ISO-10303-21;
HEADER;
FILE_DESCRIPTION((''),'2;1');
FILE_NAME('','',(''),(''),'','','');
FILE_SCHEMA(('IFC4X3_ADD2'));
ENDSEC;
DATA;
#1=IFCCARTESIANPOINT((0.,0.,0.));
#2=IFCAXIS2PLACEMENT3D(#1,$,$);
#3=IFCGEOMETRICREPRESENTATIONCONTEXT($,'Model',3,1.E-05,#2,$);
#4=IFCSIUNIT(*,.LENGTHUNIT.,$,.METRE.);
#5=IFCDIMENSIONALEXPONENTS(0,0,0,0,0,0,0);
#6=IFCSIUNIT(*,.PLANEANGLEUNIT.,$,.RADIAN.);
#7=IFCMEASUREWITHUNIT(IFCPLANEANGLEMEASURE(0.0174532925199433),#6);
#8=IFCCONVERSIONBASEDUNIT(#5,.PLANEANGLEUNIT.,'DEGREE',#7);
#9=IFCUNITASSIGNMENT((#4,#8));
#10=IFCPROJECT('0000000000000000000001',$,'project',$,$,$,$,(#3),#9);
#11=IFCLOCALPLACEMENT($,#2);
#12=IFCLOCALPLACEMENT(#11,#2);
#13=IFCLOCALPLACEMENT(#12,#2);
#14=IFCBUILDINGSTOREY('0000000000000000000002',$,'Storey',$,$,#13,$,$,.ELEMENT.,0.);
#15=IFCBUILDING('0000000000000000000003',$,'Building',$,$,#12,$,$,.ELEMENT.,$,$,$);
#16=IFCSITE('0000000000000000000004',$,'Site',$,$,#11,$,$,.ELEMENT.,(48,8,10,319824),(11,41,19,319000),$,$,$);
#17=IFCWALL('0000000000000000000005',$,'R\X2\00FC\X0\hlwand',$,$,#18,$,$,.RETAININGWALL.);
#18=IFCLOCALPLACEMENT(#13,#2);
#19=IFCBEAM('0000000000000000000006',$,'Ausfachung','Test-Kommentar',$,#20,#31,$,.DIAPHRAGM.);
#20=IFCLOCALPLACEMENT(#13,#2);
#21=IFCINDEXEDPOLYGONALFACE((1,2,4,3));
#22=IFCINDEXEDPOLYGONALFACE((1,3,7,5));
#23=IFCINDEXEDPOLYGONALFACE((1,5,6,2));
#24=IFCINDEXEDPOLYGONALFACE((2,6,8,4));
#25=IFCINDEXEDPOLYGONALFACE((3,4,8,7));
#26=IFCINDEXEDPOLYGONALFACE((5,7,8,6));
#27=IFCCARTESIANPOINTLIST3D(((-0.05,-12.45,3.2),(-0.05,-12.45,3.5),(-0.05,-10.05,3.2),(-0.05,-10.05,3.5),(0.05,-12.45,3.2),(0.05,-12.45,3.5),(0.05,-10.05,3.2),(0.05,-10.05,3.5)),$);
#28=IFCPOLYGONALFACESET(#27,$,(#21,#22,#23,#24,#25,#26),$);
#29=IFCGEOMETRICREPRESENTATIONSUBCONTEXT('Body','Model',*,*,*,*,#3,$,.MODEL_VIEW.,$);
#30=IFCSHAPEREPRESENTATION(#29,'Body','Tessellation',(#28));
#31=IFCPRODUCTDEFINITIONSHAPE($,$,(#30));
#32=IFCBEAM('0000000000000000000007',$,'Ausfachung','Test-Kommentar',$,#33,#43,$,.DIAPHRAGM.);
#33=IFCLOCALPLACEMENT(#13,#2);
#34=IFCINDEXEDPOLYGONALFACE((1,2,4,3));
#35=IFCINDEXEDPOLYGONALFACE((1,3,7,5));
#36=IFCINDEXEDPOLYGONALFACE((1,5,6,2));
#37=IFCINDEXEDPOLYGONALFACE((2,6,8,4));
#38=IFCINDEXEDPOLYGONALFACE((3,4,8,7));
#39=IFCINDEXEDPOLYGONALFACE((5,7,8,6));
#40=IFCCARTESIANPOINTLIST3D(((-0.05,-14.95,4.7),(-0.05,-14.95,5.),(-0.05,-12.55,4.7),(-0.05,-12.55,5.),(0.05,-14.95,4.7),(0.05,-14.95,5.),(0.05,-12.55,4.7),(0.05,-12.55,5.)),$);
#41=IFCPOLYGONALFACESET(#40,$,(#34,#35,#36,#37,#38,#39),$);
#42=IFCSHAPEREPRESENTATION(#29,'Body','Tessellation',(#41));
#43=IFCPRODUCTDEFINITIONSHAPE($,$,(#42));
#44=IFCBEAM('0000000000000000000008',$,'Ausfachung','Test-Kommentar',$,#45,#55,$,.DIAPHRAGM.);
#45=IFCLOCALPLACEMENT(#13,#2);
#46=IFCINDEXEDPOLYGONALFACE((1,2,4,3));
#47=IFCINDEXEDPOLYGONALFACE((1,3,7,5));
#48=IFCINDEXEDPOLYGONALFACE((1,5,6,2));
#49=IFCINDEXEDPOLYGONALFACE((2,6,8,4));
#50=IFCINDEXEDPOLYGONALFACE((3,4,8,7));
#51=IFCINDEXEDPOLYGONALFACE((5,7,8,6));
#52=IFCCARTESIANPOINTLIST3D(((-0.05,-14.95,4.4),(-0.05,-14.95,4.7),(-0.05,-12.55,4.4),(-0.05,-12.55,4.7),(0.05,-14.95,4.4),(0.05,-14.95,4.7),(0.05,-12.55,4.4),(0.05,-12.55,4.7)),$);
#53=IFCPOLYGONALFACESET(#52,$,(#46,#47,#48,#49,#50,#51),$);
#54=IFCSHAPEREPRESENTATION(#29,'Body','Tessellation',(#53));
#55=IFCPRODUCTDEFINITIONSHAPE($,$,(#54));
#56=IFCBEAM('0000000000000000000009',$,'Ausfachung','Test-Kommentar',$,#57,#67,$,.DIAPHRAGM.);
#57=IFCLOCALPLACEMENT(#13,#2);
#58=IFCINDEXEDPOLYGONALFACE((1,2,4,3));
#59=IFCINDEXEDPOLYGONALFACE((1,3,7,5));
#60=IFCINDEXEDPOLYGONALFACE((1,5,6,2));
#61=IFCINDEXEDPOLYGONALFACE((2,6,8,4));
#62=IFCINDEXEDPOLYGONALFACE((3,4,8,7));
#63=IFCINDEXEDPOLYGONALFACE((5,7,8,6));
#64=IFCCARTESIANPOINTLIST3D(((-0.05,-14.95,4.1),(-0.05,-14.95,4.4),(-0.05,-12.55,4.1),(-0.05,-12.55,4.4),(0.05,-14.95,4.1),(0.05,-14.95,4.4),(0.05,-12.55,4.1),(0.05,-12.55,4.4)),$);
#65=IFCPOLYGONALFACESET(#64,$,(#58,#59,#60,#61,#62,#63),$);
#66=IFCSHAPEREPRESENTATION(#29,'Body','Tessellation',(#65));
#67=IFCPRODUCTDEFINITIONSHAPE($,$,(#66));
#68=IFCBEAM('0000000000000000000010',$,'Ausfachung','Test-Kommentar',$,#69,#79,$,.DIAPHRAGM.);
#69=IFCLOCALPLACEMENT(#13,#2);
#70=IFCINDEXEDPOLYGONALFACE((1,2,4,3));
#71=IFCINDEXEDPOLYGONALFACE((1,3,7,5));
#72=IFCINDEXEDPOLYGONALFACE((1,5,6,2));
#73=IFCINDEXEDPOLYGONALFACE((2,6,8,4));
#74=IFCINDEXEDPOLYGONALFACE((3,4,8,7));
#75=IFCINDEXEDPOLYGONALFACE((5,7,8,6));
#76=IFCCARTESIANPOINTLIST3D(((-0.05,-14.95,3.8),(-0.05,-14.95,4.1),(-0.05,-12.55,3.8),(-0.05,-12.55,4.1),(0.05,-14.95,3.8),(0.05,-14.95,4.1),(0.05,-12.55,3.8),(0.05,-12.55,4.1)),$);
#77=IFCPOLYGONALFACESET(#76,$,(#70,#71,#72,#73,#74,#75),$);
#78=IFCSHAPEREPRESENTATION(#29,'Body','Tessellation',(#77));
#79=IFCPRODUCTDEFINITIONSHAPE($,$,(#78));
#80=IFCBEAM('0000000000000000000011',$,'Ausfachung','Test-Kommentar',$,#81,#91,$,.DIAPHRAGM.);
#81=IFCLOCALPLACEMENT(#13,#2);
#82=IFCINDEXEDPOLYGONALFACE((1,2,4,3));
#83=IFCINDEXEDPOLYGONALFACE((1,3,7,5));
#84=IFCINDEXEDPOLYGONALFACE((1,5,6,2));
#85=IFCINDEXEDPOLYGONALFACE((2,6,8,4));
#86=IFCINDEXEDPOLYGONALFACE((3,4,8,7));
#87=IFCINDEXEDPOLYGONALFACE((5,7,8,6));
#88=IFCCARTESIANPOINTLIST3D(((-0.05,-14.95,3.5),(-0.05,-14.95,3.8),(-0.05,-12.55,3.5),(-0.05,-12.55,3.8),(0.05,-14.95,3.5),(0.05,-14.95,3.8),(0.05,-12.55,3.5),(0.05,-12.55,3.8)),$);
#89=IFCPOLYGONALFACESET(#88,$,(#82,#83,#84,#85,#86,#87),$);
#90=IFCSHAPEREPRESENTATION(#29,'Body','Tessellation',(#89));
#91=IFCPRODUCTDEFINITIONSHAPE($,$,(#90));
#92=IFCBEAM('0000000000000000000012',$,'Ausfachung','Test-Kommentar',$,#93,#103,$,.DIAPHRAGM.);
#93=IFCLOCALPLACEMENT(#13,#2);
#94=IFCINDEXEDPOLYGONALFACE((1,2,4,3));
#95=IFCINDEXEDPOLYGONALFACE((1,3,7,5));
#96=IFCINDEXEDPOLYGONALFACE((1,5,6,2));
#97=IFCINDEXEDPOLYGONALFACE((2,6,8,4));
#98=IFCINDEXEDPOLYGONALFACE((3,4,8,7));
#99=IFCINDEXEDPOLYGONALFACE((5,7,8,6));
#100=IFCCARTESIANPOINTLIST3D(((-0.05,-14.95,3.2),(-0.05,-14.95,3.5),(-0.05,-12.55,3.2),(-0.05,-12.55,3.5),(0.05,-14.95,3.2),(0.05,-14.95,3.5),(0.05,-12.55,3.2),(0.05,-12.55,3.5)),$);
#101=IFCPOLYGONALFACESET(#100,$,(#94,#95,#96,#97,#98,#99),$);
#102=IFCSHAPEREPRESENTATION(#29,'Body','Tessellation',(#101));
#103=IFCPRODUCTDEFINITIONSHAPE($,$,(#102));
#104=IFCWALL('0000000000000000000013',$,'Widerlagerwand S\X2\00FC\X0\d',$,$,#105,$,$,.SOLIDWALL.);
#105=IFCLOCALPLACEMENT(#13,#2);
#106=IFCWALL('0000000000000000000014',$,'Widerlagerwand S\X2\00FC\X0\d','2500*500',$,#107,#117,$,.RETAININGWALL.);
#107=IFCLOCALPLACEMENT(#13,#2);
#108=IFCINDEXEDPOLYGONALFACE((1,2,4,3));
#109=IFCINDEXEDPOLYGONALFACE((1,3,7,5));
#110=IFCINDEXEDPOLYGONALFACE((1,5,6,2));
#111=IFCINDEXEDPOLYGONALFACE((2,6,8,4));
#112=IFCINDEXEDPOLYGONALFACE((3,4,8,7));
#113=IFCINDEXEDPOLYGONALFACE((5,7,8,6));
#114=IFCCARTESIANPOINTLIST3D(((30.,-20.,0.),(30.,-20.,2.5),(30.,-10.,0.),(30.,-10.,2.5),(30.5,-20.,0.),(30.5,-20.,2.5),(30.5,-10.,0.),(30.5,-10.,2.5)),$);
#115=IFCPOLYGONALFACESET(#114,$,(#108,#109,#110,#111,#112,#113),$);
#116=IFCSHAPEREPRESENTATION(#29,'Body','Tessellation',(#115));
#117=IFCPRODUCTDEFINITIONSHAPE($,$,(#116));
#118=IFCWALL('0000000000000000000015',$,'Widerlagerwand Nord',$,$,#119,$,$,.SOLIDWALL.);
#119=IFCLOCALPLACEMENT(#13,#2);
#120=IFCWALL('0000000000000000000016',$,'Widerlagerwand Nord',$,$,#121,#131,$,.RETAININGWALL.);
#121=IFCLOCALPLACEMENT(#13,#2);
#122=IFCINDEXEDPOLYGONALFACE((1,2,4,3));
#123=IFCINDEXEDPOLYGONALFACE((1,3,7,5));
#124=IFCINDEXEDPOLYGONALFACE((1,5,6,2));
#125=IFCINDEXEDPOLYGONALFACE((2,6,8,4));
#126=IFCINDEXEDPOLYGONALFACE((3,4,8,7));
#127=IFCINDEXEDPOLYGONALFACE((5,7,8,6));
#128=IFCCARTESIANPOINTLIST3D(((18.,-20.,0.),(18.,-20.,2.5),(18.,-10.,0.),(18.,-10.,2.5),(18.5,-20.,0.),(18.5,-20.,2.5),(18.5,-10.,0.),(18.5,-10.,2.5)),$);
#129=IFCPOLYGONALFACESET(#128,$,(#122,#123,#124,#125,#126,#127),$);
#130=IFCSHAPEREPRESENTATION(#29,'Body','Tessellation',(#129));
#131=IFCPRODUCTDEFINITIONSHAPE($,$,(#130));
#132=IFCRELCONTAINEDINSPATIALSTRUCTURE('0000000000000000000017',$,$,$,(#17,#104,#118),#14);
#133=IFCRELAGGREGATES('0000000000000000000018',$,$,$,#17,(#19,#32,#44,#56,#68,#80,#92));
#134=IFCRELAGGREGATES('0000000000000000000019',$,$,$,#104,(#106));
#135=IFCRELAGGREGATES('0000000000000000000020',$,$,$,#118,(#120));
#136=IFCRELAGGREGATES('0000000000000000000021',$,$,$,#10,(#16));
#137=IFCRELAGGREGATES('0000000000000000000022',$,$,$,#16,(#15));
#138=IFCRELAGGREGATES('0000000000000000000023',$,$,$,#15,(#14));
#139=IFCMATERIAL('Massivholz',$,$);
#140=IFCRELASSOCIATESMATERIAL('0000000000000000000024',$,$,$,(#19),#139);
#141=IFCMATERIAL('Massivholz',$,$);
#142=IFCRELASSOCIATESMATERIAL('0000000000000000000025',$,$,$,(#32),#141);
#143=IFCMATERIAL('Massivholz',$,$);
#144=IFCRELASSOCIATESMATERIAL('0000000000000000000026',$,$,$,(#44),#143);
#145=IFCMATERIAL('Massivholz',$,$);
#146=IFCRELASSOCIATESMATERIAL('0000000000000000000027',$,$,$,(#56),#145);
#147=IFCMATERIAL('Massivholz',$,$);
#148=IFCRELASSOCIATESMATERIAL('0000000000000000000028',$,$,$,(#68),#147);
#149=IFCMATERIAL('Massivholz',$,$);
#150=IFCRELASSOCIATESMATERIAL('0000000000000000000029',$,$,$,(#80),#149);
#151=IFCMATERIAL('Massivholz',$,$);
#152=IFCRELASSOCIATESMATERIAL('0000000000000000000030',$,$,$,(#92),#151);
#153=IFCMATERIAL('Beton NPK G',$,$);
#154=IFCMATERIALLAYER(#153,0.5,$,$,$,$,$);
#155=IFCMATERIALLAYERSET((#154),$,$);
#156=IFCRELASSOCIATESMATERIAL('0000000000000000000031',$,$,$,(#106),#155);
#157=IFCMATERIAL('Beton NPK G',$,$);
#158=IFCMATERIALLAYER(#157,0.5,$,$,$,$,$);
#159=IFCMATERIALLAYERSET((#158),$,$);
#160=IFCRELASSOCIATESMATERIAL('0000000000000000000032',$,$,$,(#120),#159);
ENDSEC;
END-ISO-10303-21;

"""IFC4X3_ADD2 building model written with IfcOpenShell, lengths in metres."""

from ifc_helpers import new_model, entity, si_unit, converted_unit, frame, frame_2d, origin, origin_with_axes, place, context, subcontext, project, spatial, rectangle, extrude, material, layer, layer_set, layer_usage, element, aggregate, save


model = new_model("IFC4X3_ADD2")

# Units and contexts
model_context = context("Model", 3, precision=1e-05, world=origin())
body_context = subcontext(model_context, "Body", "Model", "MODEL_VIEW")
ifc_project = project(units=[si_unit("LENGTHUNIT", "METRE"), converted_unit("PLANEANGLEUNIT", "DEGREE", entity("IfcPlaneAngleMeasure", 0.0174532925199433), si_unit("PLANEANGLEUNIT", "RADIAN"), dimensions=[0, 0, 0, 0, 0, 0, 0])], contexts=[model_context])

# Site, building, storey
site_placement = place(None, origin())
site = spatial("IfcSite", under=ifc_project, at=site_placement, Name="Site", CompositionType="ELEMENT", RefLatitude=(48, 8, 10, 319824), RefLongitude=(11, 41, 19, 319000))
building_placement = place(site_placement, origin())
building = spatial("IfcBuilding", under=site, at=building_placement, Name="Building", CompositionType="ELEMENT")
storey_placement = place(building_placement, origin())
storey = spatial("IfcBuildingStorey", under=building, at=storey_placement, Name="Storey", CompositionType="ELEMENT", Elevation=0.0)

# Wall, beams
wall_1_placement = place(storey_placement, origin())
wall_1 = element("IfcWall", 1, at=wall_1_placement, inside=storey, Name="Rühlwand", PredefinedType="RETAININGWALL")
ifc_material_1 = material(Name="Massivholz")
beam_1_placement = place(wall_1_placement, frame((0.05, -10.05, 3.2), z_axis=(0.0, 0.0, 1.0), x_axis=(-1.0, 0.0, 0.0)))
beam_1 = element("IfcBeam", 2, at=beam_1_placement, material=ifc_material_1, Name="Ausfachung", Description="Test-Kommentar", PredefinedType="DIAPHRAGM", context=body_context, shape_type="SweptSolid", body=[
    extrude(rectangle(XDim=2.4, YDim=0.3, at=frame_2d((1.2, 0.15), x_axis=(1.0, 0.0))), frame((0.0, 0.0, 0.0), z_axis=(1.0, 0.0, 0.0), x_axis=(0.0, 1.0, 0.0)), (0.0, 0.0, 1.0), 0.1),
])
ifc_material_2 = material(Name="Massivholz")
beam_2_placement = place(wall_1_placement, frame((0.05, -12.55, 4.7), z_axis=(0.0, 0.0, 1.0), x_axis=(-1.0, 0.0, 0.0)))
beam_2 = element("IfcBeam", 3, at=beam_2_placement, material=ifc_material_2, Name="Ausfachung", Description="Test-Kommentar", PredefinedType="DIAPHRAGM", context=body_context, shape_type="SweptSolid", body=[
    extrude(rectangle(XDim=2.4, YDim=0.3, at=frame_2d((1.2, 0.15), x_axis=(1.0, 0.0))), frame((0.0, 0.0, 0.0), z_axis=(1.0, 0.0, 0.0), x_axis=(0.0, 1.0, 0.0)), (0.0, 0.0, 1.0), 0.1),
])
ifc_material_3 = material(Name="Massivholz")
beam_3_placement = place(wall_1_placement, frame((0.05, -12.55, 4.4), z_axis=(0.0, 0.0, 1.0), x_axis=(-1.0, 0.0, 0.0)))
beam_3 = element("IfcBeam", 4, at=beam_3_placement, material=ifc_material_3, Name="Ausfachung", Description="Test-Kommentar", PredefinedType="DIAPHRAGM", context=body_context, shape_type="SweptSolid", body=[
    extrude(rectangle(XDim=2.4, YDim=0.3, at=frame_2d((1.2, 0.15), x_axis=(1.0, 0.0))), frame((0.0, 0.0, 0.0), z_axis=(1.0, 0.0, 0.0), x_axis=(0.0, 1.0, 0.0)), (0.0, 0.0, 1.0), 0.1),
])
ifc_material_4 = material(Name="Massivholz")
beam_4_placement = place(wall_1_placement, frame((0.05, -12.55, 4.1), z_axis=(0.0, 0.0, 1.0), x_axis=(-1.0, 0.0, 0.0)))
beam_4 = element("IfcBeam", 5, at=beam_4_placement, material=ifc_material_4, Name="Ausfachung", Description="Test-Kommentar", PredefinedType="DIAPHRAGM", context=body_context, shape_type="SweptSolid", body=[
    extrude(rectangle(XDim=2.4, YDim=0.3, at=frame_2d((1.2, 0.15), x_axis=(1.0, 0.0))), frame((0.0, 0.0, 0.0), z_axis=(1.0, 0.0, 0.0), x_axis=(0.0, 1.0, 0.0)), (0.0, 0.0, 1.0), 0.1),
])
ifc_material_5 = material(Name="Massivholz")
beam_5_placement = place(wall_1_placement, frame((0.05, -12.55, 3.8), z_axis=(0.0, 0.0, 1.0), x_axis=(-1.0, 0.0, 0.0)))
beam_5 = element("IfcBeam", 6, at=beam_5_placement, material=ifc_material_5, Name="Ausfachung", Description="Test-Kommentar", PredefinedType="DIAPHRAGM", context=body_context, shape_type="SweptSolid", body=[
    extrude(rectangle(XDim=2.4, YDim=0.3, at=frame_2d((1.2, 0.15), x_axis=(1.0, 0.0))), frame((0.0, 0.0, 0.0), z_axis=(1.0, 0.0, 0.0), x_axis=(0.0, 1.0, 0.0)), (0.0, 0.0, 1.0), 0.1),
])
ifc_material_6 = material(Name="Massivholz")
beam_6_placement = place(wall_1_placement, frame((0.05, -12.55, 3.5), z_axis=(0.0, 0.0, 1.0), x_axis=(-1.0, 0.0, 0.0)))
beam_6 = element("IfcBeam", 7, at=beam_6_placement, material=ifc_material_6, Name="Ausfachung", Description="Test-Kommentar", PredefinedType="DIAPHRAGM", context=body_context, shape_type="SweptSolid", body=[
    extrude(rectangle(XDim=2.4, YDim=0.3, at=frame_2d((1.2, 0.15), x_axis=(1.0, 0.0))), frame((0.0, 0.0, 0.0), z_axis=(1.0, 0.0, 0.0), x_axis=(0.0, 1.0, 0.0)), (0.0, 0.0, 1.0), 0.1),
])
ifc_material_7 = material(Name="Massivholz")
beam_7_placement = place(wall_1_placement, frame((0.05, -12.55, 3.2), z_axis=(0.0, 0.0, 1.0), x_axis=(-1.0, 0.0, 0.0)))
beam_7 = element("IfcBeam", 8, at=beam_7_placement, material=ifc_material_7, Name="Ausfachung", Description="Test-Kommentar", PredefinedType="DIAPHRAGM", context=body_context, shape_type="SweptSolid", body=[
    extrude(rectangle(XDim=2.4, YDim=0.3, at=frame_2d((1.2, 0.15), x_axis=(1.0, 0.0))), frame((0.0, 0.0, 0.0), z_axis=(1.0, 0.0, 0.0), x_axis=(0.0, 1.0, 0.0)), (0.0, 0.0, 1.0), 0.1),
])
aggregate(wall_1, [beam_1, beam_2, beam_3, beam_4, beam_5, beam_6, beam_7])

# Walls
wall_2_placement = place(storey_placement, origin())
wall_2 = element("IfcWall", 9, at=wall_2_placement, inside=storey, Name="Widerlagerwand Süd", PredefinedType="SOLIDWALL")
ifc_material_8 = material(Name="Beton NPK G")
ifc_layer_1 = layer(ifc_material_8, 0.5)
ifc_layer_set_1 = layer_set([ifc_layer_1])
ifc_layer_usage_1 = layer_usage(ifc_layer_set_1, "AXIS2", "POSITIVE", 0.0)
wall_3_placement = place(wall_2_placement, frame((30.5, -20.0, 0.0), z_axis=(0.0, 0.0, 1.0), x_axis=(0.0, 1.0, 0.0)))
wall_3 = element("IfcWall", 10, at=wall_3_placement, material=ifc_layer_usage_1, Name="Widerlagerwand Süd", Description="2500*500", PredefinedType="RETAININGWALL", context=body_context, shape_type="SweptSolid", body=[
    extrude(rectangle(XDim=10.0, YDim=0.5, at=frame_2d((5.0, 0.25), x_axis=(1.0, 0.0))), origin_with_axes(), (0.0, 0.0, 1.0), 2.5),
])
aggregate(wall_2, [wall_3])
wall_4_placement = place(storey_placement, origin())
wall_4 = element("IfcWall", 11, at=wall_4_placement, inside=storey, Name="Widerlagerwand Nord", PredefinedType="SOLIDWALL")
ifc_material_9 = material(Name="Beton NPK G")
ifc_layer_2 = layer(ifc_material_9, 0.5)
ifc_layer_set_2 = layer_set([ifc_layer_2])
ifc_layer_usage_2 = layer_usage(ifc_layer_set_2, "AXIS2", "POSITIVE", 0.0)
wall_5_placement = place(wall_4_placement, frame((18.5, -20.0, 0.0), z_axis=(0.0, 0.0, 1.0), x_axis=(0.0, 1.0, 0.0)))
wall_5 = element("IfcWall", 12, at=wall_5_placement, material=ifc_layer_usage_2, Name="Widerlagerwand Nord", PredefinedType="RETAININGWALL", context=body_context, shape_type="SweptSolid", body=[
    extrude(rectangle(XDim=10.0, YDim=0.5, at=frame_2d((5.0, 0.25), x_axis=(1.0, 0.0))), origin_with_axes(), (0.0, 0.0, 1.0), 2.5),
])
aggregate(wall_4, [wall_5])

save(model, "model.ifc")
